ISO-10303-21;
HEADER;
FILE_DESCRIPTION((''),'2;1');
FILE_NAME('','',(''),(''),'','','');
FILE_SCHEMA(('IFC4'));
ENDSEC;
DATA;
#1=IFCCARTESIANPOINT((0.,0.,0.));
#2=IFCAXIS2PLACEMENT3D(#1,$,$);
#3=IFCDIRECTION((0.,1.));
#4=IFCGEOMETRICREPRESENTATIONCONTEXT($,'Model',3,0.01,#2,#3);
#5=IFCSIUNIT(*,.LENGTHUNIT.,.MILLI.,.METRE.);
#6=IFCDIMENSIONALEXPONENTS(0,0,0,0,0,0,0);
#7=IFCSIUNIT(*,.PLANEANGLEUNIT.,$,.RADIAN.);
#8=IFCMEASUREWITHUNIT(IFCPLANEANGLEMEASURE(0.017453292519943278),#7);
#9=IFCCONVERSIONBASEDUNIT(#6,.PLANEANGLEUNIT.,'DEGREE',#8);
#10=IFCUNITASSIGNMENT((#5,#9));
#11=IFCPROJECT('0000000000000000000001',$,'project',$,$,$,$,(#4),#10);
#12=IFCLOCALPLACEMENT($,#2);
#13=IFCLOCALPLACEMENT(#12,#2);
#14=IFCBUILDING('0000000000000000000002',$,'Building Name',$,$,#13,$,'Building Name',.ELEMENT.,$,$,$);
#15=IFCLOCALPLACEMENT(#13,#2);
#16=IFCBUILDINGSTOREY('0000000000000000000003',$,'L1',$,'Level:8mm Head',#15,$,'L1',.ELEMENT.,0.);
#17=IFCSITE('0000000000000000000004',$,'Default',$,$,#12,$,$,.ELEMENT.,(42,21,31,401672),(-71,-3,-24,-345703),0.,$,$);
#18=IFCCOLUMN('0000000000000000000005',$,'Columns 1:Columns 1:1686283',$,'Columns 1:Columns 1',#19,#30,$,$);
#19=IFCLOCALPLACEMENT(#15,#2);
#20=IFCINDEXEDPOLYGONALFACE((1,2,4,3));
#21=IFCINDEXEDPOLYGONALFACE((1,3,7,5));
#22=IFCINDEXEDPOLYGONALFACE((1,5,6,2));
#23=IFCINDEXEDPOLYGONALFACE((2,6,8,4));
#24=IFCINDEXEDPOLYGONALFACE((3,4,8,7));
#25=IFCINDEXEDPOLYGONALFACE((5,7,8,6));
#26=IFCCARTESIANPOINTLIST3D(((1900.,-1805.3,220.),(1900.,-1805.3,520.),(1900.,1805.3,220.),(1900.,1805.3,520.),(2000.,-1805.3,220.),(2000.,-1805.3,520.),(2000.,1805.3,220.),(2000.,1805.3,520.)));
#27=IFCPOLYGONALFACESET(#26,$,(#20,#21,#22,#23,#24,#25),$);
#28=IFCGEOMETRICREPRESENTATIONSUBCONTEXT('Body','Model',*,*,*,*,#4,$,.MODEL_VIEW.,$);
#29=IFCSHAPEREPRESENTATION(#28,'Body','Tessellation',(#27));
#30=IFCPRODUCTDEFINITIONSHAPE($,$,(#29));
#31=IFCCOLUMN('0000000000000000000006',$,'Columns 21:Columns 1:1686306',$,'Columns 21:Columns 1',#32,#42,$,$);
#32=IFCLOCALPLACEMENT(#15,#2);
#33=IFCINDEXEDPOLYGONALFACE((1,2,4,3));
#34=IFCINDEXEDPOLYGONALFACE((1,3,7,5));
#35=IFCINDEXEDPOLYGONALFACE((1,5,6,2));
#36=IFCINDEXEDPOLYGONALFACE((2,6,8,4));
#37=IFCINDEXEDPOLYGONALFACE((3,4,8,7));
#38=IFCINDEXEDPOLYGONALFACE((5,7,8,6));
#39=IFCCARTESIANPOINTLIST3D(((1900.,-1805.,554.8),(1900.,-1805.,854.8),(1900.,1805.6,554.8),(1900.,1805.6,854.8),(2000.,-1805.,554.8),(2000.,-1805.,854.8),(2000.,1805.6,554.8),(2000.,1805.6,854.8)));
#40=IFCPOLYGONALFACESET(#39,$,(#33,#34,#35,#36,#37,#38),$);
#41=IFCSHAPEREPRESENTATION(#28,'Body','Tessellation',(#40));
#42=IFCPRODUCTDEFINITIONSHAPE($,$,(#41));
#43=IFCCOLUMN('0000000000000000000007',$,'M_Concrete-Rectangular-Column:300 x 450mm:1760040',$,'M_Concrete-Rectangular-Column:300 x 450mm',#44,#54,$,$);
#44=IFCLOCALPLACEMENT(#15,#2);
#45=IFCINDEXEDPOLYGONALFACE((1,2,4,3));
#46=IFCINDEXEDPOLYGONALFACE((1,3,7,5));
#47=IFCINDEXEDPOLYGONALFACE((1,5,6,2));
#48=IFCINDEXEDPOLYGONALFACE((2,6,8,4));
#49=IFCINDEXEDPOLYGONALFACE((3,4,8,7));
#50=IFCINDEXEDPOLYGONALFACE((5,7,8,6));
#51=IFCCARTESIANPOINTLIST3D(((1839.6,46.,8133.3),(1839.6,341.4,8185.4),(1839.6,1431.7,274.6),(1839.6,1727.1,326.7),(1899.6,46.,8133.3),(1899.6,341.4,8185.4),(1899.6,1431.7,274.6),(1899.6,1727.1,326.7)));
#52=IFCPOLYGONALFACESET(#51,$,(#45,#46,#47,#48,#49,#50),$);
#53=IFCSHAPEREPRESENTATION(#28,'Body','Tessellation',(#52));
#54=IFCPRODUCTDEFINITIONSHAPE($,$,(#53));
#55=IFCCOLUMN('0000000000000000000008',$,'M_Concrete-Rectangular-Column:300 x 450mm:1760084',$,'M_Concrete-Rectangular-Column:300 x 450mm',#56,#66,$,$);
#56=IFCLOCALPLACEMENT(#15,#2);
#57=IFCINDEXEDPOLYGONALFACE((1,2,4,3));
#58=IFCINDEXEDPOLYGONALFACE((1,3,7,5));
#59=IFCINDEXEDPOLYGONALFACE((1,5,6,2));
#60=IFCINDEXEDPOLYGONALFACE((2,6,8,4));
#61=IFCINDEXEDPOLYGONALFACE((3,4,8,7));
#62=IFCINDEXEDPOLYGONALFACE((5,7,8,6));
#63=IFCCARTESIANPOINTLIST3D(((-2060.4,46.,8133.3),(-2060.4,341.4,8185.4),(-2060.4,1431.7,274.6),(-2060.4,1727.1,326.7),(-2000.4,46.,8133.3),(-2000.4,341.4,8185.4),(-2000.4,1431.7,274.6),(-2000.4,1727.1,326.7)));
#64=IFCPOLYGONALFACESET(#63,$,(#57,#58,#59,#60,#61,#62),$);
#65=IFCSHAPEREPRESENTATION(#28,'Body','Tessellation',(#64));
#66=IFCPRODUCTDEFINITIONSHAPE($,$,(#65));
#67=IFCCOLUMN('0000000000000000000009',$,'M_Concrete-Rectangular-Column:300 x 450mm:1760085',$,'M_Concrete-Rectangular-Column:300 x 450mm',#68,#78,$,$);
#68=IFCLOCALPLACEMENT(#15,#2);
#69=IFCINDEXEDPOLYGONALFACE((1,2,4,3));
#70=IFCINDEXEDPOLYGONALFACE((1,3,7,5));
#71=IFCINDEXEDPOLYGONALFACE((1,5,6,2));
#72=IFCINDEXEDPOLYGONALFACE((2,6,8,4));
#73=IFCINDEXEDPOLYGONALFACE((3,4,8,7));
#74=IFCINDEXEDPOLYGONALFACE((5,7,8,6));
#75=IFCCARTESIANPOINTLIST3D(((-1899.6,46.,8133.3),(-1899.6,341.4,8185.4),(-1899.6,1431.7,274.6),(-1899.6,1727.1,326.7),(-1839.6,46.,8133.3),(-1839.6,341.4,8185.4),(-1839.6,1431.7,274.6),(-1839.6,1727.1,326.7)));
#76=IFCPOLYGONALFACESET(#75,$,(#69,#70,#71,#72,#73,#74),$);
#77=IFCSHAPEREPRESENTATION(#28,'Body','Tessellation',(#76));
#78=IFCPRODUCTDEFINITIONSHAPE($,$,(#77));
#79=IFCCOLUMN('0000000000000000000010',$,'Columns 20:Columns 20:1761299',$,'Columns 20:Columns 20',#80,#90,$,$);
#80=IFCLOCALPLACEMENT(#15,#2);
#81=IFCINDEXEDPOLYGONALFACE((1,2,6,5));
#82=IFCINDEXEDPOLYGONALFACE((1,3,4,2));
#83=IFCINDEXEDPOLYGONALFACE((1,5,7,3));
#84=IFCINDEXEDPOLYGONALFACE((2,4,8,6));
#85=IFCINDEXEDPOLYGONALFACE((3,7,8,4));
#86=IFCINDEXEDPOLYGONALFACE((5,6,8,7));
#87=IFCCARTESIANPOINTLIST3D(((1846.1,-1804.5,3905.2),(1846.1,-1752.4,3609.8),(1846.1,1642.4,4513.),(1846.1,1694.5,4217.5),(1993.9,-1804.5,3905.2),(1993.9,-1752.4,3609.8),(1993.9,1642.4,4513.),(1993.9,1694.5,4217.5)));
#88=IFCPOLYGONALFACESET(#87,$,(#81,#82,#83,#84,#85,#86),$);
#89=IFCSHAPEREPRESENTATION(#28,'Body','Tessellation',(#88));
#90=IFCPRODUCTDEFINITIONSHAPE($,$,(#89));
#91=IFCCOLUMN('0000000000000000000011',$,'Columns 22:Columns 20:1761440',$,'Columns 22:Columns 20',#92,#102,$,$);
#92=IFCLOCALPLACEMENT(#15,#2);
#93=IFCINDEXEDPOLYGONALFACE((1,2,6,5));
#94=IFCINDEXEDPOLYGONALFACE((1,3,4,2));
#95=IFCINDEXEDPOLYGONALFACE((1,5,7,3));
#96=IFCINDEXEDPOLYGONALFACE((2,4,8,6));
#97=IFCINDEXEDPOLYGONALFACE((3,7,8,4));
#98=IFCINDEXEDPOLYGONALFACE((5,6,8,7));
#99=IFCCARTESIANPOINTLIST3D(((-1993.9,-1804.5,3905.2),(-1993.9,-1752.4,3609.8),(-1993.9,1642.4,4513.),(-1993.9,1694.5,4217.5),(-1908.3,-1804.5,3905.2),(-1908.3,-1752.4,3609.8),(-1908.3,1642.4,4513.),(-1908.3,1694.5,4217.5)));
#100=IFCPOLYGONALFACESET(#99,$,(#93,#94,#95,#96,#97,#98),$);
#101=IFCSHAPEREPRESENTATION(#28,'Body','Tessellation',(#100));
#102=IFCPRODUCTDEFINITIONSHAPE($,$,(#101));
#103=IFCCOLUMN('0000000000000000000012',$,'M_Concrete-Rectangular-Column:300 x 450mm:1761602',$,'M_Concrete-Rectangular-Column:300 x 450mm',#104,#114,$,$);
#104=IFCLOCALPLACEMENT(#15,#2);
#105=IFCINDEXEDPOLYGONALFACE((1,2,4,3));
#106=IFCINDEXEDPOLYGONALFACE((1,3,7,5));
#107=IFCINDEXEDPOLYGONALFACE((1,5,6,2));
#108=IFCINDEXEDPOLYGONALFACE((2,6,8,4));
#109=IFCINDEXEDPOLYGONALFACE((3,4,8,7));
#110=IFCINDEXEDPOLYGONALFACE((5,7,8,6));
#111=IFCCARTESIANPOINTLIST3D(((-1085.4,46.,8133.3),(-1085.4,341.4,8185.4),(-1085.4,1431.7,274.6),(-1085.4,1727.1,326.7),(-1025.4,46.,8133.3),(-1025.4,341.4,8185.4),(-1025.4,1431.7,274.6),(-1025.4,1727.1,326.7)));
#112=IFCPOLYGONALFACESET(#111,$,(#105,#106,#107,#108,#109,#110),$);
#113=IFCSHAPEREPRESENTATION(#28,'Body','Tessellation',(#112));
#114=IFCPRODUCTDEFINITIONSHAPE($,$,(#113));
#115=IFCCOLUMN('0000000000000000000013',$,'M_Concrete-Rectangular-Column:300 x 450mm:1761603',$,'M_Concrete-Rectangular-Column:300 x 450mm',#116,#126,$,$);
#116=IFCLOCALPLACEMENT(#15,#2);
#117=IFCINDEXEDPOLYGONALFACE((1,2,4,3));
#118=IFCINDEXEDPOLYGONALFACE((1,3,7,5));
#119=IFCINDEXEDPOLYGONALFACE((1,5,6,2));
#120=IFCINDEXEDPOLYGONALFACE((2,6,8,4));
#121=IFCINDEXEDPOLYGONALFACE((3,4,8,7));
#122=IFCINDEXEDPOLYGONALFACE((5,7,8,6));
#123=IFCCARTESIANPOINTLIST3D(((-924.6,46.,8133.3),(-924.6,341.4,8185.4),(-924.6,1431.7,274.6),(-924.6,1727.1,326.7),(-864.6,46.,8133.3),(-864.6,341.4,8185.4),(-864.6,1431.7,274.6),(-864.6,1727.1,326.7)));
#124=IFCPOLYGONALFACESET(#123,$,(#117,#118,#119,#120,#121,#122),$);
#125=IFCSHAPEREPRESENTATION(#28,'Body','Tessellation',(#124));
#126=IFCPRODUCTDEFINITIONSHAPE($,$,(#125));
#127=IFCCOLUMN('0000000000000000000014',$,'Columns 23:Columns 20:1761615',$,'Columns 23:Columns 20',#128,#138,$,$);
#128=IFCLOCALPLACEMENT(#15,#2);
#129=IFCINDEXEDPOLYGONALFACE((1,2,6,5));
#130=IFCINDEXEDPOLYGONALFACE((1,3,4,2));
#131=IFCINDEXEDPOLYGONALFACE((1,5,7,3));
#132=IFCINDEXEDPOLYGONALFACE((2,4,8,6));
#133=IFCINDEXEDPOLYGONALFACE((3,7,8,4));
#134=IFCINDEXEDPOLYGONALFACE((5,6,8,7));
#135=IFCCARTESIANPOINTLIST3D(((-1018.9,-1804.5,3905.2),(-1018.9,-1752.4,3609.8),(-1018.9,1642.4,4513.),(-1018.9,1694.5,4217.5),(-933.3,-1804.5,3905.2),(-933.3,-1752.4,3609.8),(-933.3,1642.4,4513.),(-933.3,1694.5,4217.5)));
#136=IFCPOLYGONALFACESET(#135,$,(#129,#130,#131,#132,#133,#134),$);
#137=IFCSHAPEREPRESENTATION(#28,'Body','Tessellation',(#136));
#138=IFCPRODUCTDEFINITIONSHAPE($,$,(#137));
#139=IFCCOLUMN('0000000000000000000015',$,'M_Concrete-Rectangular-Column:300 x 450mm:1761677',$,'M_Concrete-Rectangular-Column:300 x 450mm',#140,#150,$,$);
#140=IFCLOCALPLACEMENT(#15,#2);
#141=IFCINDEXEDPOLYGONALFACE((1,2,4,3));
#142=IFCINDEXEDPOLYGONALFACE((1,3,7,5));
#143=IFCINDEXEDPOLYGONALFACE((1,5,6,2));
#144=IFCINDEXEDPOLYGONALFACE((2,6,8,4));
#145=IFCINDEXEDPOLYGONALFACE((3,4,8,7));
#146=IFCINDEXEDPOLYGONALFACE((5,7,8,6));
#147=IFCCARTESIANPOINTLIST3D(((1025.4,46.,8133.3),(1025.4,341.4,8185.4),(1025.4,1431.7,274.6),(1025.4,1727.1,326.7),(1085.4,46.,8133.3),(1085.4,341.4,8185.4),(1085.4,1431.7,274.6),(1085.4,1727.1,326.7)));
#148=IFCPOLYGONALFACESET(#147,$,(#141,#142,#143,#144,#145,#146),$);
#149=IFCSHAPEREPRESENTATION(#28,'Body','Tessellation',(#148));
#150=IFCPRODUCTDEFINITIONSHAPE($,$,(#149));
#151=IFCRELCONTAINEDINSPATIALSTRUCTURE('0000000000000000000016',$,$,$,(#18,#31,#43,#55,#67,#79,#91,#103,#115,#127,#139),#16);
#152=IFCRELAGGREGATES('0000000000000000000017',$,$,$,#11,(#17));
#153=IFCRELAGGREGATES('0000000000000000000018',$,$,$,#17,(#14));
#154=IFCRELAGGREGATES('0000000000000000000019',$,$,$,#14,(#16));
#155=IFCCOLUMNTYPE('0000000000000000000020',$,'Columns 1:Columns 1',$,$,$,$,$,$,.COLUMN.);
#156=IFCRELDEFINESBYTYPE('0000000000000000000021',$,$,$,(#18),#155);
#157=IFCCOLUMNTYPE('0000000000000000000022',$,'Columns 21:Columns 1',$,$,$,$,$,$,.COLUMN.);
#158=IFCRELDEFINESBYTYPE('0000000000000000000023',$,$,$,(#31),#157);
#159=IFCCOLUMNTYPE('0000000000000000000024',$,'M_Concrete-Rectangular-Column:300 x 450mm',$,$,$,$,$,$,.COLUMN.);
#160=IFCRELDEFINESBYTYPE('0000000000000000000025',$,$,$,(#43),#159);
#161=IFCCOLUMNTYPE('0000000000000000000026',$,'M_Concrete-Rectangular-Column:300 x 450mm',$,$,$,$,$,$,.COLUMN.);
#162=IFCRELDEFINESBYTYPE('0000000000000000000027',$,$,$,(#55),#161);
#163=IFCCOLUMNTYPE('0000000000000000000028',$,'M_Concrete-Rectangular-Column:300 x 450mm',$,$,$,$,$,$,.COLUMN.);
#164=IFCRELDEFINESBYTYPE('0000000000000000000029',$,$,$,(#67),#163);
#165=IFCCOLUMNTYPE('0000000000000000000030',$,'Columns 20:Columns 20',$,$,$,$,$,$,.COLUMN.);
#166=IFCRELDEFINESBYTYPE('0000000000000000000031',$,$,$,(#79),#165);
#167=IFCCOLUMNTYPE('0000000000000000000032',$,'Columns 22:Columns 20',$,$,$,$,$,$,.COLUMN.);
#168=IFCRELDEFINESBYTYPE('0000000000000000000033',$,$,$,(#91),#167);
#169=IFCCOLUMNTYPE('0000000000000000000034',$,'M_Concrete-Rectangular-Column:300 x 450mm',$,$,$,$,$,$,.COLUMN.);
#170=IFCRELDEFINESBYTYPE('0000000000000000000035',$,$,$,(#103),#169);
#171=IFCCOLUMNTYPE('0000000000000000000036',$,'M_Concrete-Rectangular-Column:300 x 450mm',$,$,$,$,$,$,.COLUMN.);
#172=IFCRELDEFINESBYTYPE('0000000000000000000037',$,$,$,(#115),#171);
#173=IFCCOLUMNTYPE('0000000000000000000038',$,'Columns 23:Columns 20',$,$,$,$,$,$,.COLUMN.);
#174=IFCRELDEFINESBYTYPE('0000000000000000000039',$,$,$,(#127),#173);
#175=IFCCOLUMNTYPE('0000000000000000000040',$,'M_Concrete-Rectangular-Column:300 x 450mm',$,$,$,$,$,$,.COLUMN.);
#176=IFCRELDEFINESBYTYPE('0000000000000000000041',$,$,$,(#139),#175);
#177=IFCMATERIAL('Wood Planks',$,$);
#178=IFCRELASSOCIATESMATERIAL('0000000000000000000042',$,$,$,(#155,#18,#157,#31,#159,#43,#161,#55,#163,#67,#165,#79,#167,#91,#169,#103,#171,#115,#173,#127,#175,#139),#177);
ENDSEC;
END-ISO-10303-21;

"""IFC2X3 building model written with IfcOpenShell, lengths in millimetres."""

from ifc_helpers import new_model, entity, si_unit, converted_unit, direction, frame, frame_2d, origin, origin_2d_with_axis, place, context, subcontext, project, spatial, rectangle, extrude, source, transform, mapped, material, type_object, type_shapes, element, save


model = new_model("IFC2X3")

# Units and contexts
model_context = context("Model", 3, precision=0.01, world=origin(), true_north=direction((0.0, 1.0)))
body_context = subcontext(model_context, "Body", "Model", "MODEL_VIEW")
ifc_project = project(units=[si_unit("LENGTHUNIT", "METRE", prefix="MILLI"), converted_unit("PLANEANGLEUNIT", "DEGREE", entity("IfcPlaneAngleMeasure", 0.017453292519943278), si_unit("PLANEANGLEUNIT", "RADIAN"), dimensions=[0, 0, 0, 0, 0, 0, 0])], contexts=[model_context])

# Site, building, storey
site_placement = place(None, origin())
site = spatial("IfcSite", under=ifc_project, at=site_placement, Name="Default", CompositionType="ELEMENT", RefLatitude=(42, 21, 31, 401672), RefLongitude=(-71, -3, -24, -345703), RefElevation=0.0)
building_placement = place(site_placement, origin())
building = spatial("IfcBuilding", under=site, at=building_placement, Name="Building Name", LongName="Building Name", CompositionType="ELEMENT")
storey_placement = place(building_placement, origin())
storey = spatial("IfcBuildingStorey", under=building, at=storey_placement, Name="L1", ObjectType="Level:8mm Head", LongName="L1", CompositionType="ELEMENT", Elevation=0.0)

# Columns
ifc_material_1 = material(Name="Wood Planks")
column_type_1 = type_object("IfcColumnType", Name="Columns 1:Columns 1", PredefinedType="COLUMN", material=ifc_material_1)
shared_shape_1 = source(origin(), body_context, "Body", "SweptSolid", [
    extrude(rectangle(XDim=100.0, YDim=3610.6, at=frame_2d((0.0, 0.0), x_axis=(1.0, 0.0))), frame((1950.0, 0.0, 220.0), z_axis=(0.0, 0.0, 1.0), x_axis=(-1.0, 0.0, 0.0)), (0.0, 0.0, 1.0), 300.0),
])
type_shapes(column_type_1, [shared_shape_1])
column_1_placement = place(storey_placement, origin())
element("IfcColumn", 1, at=column_1_placement, inside=storey, type_object=column_type_1, material=ifc_material_1, Name="Columns 1:Columns 1:1686283", ObjectType="Columns 1:Columns 1", context=body_context, shape_type="MappedRepresentation", body=[
    mapped(shared_shape_1, transform((0.0, 0.0, 0.0), scale=1.0)),
])
column_type_2 = type_object("IfcColumnType", Name="Columns 21:Columns 1", PredefinedType="COLUMN", material=ifc_material_1)
shared_shape_2 = source(origin(), body_context, "Body", "SweptSolid", [
    extrude(rectangle(XDim=100.0, YDim=3610.6, at=frame_2d((0.0, 0.0), x_axis=(1.0, 0.0))), frame((1950.0, 0.3, 554.8), z_axis=(0.0, 0.0, 1.0), x_axis=(-1.0, 0.0, 0.0)), (0.0, 0.0, 1.0), 300.0),
])
type_shapes(column_type_2, [shared_shape_2])
column_2_placement = place(storey_placement, origin())
element("IfcColumn", 2, at=column_2_placement, inside=storey, type_object=column_type_2, material=ifc_material_1, Name="Columns 21:Columns 1:1686306", ObjectType="Columns 21:Columns 1", context=body_context, shape_type="MappedRepresentation", body=[
    mapped(shared_shape_2, transform((0.0, 0.0, 0.0), scale=1.0)),
])
column_type_3 = type_object("IfcColumnType", Name="M_Concrete-Rectangular-Column:300 x 450mm", PredefinedType="COLUMN", material=ifc_material_1)
shared_shape_3 = source(origin(), body_context, "Body", "SweptSolid", [
    extrude(rectangle(XDim=300.0, YDim=60.0, at=frame_2d((0.0, 0.0), x_axis=(1.0, 0.0))), frame((1869.6, 1579.4, 300.6), z_axis=(0.0, -0.173648, 0.984808), x_axis=(0.0, -0.984808, -0.173648)), (0.0, 0.0, 1.0), 7980.0),
])
type_shapes(column_type_3, [shared_shape_3])
column_3_placement = place(storey_placement, origin())
element("IfcColumn", 3, at=column_3_placement, inside=storey, type_object=column_type_3, material=ifc_material_1, Name="M_Concrete-Rectangular-Column:300 x 450mm:1760040", ObjectType="M_Concrete-Rectangular-Column:300 x 450mm", context=body_context, shape_type="MappedRepresentation", body=[
    mapped(shared_shape_3, transform((0.0, 0.0, 0.0), scale=1.0)),
])
column_type_4 = type_object("IfcColumnType", Name="M_Concrete-Rectangular-Column:300 x 450mm", PredefinedType="COLUMN", material=ifc_material_1)
shared_shape_4 = source(origin(), body_context, "Body", "SweptSolid", [
    extrude(rectangle(XDim=300.0, YDim=60.0, at=frame_2d((0.0, 0.0), x_axis=(1.0, 0.0))), frame((-2030.4, 1579.4, 300.6), z_axis=(0.0, -0.173648, 0.984808), x_axis=(0.0, -0.984808, -0.173648)), (0.0, 0.0, 1.0), 7980.0),
])
type_shapes(column_type_4, [shared_shape_4])
column_4_placement = place(storey_placement, origin())
element("IfcColumn", 4, at=column_4_placement, inside=storey, type_object=column_type_4, material=ifc_material_1, Name="M_Concrete-Rectangular-Column:300 x 450mm:1760084", ObjectType="M_Concrete-Rectangular-Column:300 x 450mm", context=body_context, shape_type="MappedRepresentation", body=[
    mapped(shared_shape_4, transform((0.0, 0.0, 0.0), scale=1.0)),
])
column_type_5 = type_object("IfcColumnType", Name="M_Concrete-Rectangular-Column:300 x 450mm", PredefinedType="COLUMN", material=ifc_material_1)
shared_shape_5 = source(origin(), body_context, "Body", "SweptSolid", [
    extrude(rectangle(XDim=300.0, YDim=60.0, at=frame_2d((0.0, 0.0), x_axis=(1.0, 0.0))), frame((-1869.6, 1579.4, 300.6), z_axis=(0.0, -0.173648, 0.984808), x_axis=(0.0, -0.984808, -0.173648)), (0.0, 0.0, 1.0), 7980.0),
])
type_shapes(column_type_5, [shared_shape_5])
column_5_placement = place(storey_placement, origin())
element("IfcColumn", 5, at=column_5_placement, inside=storey, type_object=column_type_5, material=ifc_material_1, Name="M_Concrete-Rectangular-Column:300 x 450mm:1760085", ObjectType="M_Concrete-Rectangular-Column:300 x 450mm", context=body_context, shape_type="MappedRepresentation", body=[
    mapped(shared_shape_5, transform((0.0, 0.0, 0.0), scale=1.0)),
])
column_type_6 = type_object("IfcColumnType", Name="Columns 20:Columns 20", PredefinedType="COLUMN", material=ifc_material_1)
shared_shape_6 = source(origin(), body_context, "Body", "SweptSolid", [
    extrude(rectangle(XDim=300.0, YDim=147.8, at=frame_2d((0.0, 0.0), x_axis=(0.0, 1.0))), frame((1920.0, -1778.4, 3757.5), z_axis=(0.0, 0.984808, 0.173648), x_axis=(1.0, 0.0, 0.0)), (0.0, 0.0, 1.0), 3500.0),
])
type_shapes(column_type_6, [shared_shape_6])
column_6_placement = place(storey_placement, origin())
element("IfcColumn", 6, at=column_6_placement, inside=storey, type_object=column_type_6, material=ifc_material_1, Name="Columns 20:Columns 20:1761299", ObjectType="Columns 20:Columns 20", context=body_context, shape_type="MappedRepresentation", body=[
    mapped(shared_shape_6, transform((0.0, 0.0, 0.0), scale=1.0)),
])
column_type_7 = type_object("IfcColumnType", Name="Columns 22:Columns 20", PredefinedType="COLUMN", material=ifc_material_1)
shared_shape_7 = source(origin(), body_context, "Body", "SweptSolid", [
    extrude(rectangle(XDim=300.0, YDim=85.6, at=frame_2d((0.0, 0.0), x_axis=(0.0, 1.0))), frame((-1951.1, -1778.4, 3757.5), z_axis=(0.0, 0.984808, 0.173648), x_axis=(-1.0, 0.0, 0.0)), (0.0, 0.0, 1.0), 3500.0),
])
type_shapes(column_type_7, [shared_shape_7])
column_7_placement = place(storey_placement, origin())
element("IfcColumn", 7, at=column_7_placement, inside=storey, type_object=column_type_7, material=ifc_material_1, Name="Columns 22:Columns 20:1761440", ObjectType="Columns 22:Columns 20", context=body_context, shape_type="MappedRepresentation", body=[
    mapped(shared_shape_7, transform((0.0, 0.0, 0.0), scale=1.0)),
])
column_type_8 = type_object("IfcColumnType", Name="M_Concrete-Rectangular-Column:300 x 450mm", PredefinedType="COLUMN", material=ifc_material_1)
shared_shape_8 = source(origin(), body_context, "Body", "SweptSolid", [
    extrude(rectangle(XDim=300.0, YDim=60.0, at=frame_2d((0.0, 0.0), x_axis=(1.0, 0.0))), frame((-1055.4, 1579.4, 300.6), z_axis=(0.0, -0.173648, 0.984808), x_axis=(0.0, -0.984808, -0.173648)), (0.0, 0.0, 1.0), 7980.0),
])
type_shapes(column_type_8, [shared_shape_8])
column_8_placement = place(storey_placement, origin())
element("IfcColumn", 8, at=column_8_placement, inside=storey, type_object=column_type_8, material=ifc_material_1, Name="M_Concrete-Rectangular-Column:300 x 450mm:1761602", ObjectType="M_Concrete-Rectangular-Column:300 x 450mm", context=body_context, shape_type="MappedRepresentation", body=[
    mapped(shared_shape_8, transform((0.0, 0.0, 0.0), scale=1.0)),
])
column_type_9 = type_object("IfcColumnType", Name="M_Concrete-Rectangular-Column:300 x 450mm", PredefinedType="COLUMN", material=ifc_material_1)
shared_shape_9 = source(origin(), body_context, "Body", "SweptSolid", [
    extrude(rectangle(XDim=300.0, YDim=60.0, at=origin_2d_with_axis()), frame((-894.6, 1579.4, 300.6), z_axis=(0.0, -0.173648, 0.984808), x_axis=(0.0, -0.984808, -0.173648)), (0.0, 0.0, 1.0), 7980.0),
])
type_shapes(column_type_9, [shared_shape_9])
column_9_placement = place(storey_placement, origin())
element("IfcColumn", 9, at=column_9_placement, inside=storey, type_object=column_type_9, material=ifc_material_1, Name="M_Concrete-Rectangular-Column:300 x 450mm:1761603", ObjectType="M_Concrete-Rectangular-Column:300 x 450mm", context=body_context, shape_type="MappedRepresentation", body=[
    mapped(shared_shape_9, transform((0.0, 0.0, 0.0), scale=1.0)),
])
column_type_10 = type_object("IfcColumnType", Name="Columns 23:Columns 20", PredefinedType="COLUMN", material=ifc_material_1)
shared_shape_10 = source(origin(), body_context, "Body", "SweptSolid", [
    extrude(rectangle(XDim=300.0, YDim=85.6, at=frame_2d((0.0, 0.0), x_axis=(0.0, 1.0))), frame((-976.1, -1778.4, 3757.5), z_axis=(0.0, 0.984808, 0.173648), x_axis=(-1.0, 0.0, 0.0)), (0.0, 0.0, 1.0), 3500.0),
])
type_shapes(column_type_10, [shared_shape_10])
column_10_placement = place(storey_placement, origin())
element("IfcColumn", 10, at=column_10_placement, inside=storey, type_object=column_type_10, material=ifc_material_1, Name="Columns 23:Columns 20:1761615", ObjectType="Columns 23:Columns 20", context=body_context, shape_type="MappedRepresentation", body=[
    mapped(shared_shape_10, transform((0.0, 0.0, 0.0), scale=1.0)),
])
column_type_11 = type_object("IfcColumnType", Name="M_Concrete-Rectangular-Column:300 x 450mm", PredefinedType="COLUMN", material=ifc_material_1)
shared_shape_11 = source(origin(), body_context, "Body", "SweptSolid", [
    extrude(rectangle(XDim=300.0, YDim=60.0, at=origin_2d_with_axis()), frame((1055.4, 1579.4, 300.6), z_axis=(0.0, -0.173648, 0.984808), x_axis=(0.0, -0.984808, -0.173648)), (0.0, 0.0, 1.0), 7980.0),
])
type_shapes(column_type_11, [shared_shape_11])
column_11_placement = place(storey_placement, origin())
element("IfcColumn", 11, at=column_11_placement, inside=storey, type_object=column_type_11, material=ifc_material_1, Name="M_Concrete-Rectangular-Column:300 x 450mm:1761677", ObjectType="M_Concrete-Rectangular-Column:300 x 450mm", context=body_context, shape_type="MappedRepresentation", body=[
    mapped(shared_shape_11, transform((0.0, 0.0, 0.0), scale=1.0)),
])

save(model, "model.ifc")
